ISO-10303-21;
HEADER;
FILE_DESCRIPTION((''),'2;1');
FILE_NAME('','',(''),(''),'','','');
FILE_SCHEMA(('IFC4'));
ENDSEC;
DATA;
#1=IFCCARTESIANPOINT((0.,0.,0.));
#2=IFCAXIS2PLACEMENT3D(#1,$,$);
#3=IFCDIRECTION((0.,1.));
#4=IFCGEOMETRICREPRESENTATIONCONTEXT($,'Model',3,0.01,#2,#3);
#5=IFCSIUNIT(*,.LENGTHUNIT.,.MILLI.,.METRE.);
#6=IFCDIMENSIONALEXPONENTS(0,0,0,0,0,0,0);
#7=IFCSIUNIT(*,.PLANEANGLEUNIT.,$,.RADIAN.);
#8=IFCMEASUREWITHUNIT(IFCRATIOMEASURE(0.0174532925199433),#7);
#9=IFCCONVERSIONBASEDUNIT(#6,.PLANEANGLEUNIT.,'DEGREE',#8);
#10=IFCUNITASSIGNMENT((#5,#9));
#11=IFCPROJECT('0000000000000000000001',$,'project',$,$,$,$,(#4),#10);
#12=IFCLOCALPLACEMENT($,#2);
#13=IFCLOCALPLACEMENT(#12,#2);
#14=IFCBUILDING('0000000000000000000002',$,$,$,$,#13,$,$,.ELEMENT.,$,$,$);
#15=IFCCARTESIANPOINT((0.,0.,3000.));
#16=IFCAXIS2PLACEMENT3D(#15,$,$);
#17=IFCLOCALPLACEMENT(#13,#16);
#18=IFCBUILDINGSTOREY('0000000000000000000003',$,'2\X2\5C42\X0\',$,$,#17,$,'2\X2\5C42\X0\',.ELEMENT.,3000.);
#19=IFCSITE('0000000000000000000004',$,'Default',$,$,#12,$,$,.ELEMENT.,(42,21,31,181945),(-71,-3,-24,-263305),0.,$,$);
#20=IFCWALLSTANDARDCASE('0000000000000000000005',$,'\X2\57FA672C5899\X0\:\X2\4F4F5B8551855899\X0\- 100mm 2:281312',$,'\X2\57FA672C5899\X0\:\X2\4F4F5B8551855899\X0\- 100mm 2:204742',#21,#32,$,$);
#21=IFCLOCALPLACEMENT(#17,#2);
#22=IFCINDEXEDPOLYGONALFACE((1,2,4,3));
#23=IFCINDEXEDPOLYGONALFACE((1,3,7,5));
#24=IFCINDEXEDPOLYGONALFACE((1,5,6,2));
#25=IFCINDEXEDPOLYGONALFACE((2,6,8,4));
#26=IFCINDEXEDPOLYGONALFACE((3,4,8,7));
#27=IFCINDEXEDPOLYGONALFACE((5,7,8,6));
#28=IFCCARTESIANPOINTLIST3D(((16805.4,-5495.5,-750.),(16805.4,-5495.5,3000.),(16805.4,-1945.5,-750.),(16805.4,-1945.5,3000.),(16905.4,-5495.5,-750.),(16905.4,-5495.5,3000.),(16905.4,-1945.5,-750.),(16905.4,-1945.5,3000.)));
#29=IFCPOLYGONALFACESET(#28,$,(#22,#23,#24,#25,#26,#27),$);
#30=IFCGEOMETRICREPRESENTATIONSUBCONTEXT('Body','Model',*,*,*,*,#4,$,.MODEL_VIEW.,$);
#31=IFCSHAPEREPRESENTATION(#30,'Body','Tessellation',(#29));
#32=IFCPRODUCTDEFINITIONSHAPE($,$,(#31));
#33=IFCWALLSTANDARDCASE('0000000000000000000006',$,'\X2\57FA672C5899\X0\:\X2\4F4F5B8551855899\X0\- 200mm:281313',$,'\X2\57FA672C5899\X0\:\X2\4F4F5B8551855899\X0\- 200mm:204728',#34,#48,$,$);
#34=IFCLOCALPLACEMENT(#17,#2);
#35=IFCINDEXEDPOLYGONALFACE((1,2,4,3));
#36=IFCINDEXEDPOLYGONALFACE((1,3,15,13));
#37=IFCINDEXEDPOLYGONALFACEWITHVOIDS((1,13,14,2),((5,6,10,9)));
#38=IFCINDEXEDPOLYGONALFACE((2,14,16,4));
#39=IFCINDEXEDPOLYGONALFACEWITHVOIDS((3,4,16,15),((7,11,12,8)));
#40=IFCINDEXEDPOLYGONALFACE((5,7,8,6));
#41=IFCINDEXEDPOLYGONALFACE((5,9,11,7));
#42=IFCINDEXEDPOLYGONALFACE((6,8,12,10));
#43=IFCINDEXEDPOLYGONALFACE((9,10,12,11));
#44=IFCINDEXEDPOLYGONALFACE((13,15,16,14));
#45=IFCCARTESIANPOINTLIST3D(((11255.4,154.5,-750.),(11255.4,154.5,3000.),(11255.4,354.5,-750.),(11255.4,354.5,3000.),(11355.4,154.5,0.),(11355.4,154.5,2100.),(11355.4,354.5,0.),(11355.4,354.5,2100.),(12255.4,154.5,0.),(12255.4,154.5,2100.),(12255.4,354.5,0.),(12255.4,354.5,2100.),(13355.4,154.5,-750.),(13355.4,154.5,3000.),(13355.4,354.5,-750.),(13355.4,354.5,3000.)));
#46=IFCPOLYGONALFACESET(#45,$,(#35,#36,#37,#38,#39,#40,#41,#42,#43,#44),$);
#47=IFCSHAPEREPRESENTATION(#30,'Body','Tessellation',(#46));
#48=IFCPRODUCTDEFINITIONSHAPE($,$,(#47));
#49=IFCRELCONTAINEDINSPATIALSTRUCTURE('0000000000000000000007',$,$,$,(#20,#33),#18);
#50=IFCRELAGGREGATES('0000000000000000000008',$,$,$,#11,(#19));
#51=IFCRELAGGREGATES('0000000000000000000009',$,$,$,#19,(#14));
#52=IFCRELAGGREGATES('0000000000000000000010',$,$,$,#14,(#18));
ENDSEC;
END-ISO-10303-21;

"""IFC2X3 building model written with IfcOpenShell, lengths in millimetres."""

from ifc_helpers import new_model, entity, si_unit, converted_unit, direction, frame, frame_2d, origin, place, context, subcontext, project, spatial, rectangle, extrude, element, save


model = new_model("IFC2X3")

# Units and contexts
model_context = context("Model", 3, precision=0.01, world=origin(), true_north=direction((0.0, 1.0)))
body_context = subcontext(model_context, "Body", "Model", "MODEL_VIEW")
ifc_project = project(units=[si_unit("LENGTHUNIT", "METRE", prefix="MILLI"), converted_unit("PLANEANGLEUNIT", "DEGREE", entity("IfcRatioMeasure", 0.0174532925199433), si_unit("PLANEANGLEUNIT", "RADIAN"), dimensions=[0, 0, 0, 0, 0, 0, 0])], contexts=[model_context])

# Site, building, storey
site_placement = place(None, origin())
site = spatial("IfcSite", under=ifc_project, at=site_placement, Name="Default", CompositionType="ELEMENT", RefLatitude=(42, 21, 31, 181945), RefLongitude=(-71, -3, -24, -263305), RefElevation=0.0)
building_placement = place(site_placement, origin())
building = spatial("IfcBuilding", under=site, at=building_placement, CompositionType="ELEMENT")
storey_placement = place(building_placement, frame((0.0, 0.0, 3000.0)))
storey = spatial("IfcBuildingStorey", under=building, at=storey_placement, Name="2层", LongName="2层", CompositionType="ELEMENT", Elevation=3000.0)

# Wall
wall_1_placement = place(storey_placement, frame((16855.4, -1945.5, -750.0), z_axis=(0.0, 0.0, 1.0), x_axis=(0.0, -1.0, 0.0)))
element("IfcWallStandardCase", 1, at=wall_1_placement, inside=storey, Name="基本墙:住宅内墙- 100mm 2:281312", ObjectType="基本墙:住宅内墙- 100mm 2:204742", context=body_context, shape_type="SweptSolid", body=[
    extrude(rectangle(XDim=3550.0, YDim=100.0, at=frame_2d((1775.0, 0.0), x_axis=(-1.0, 0.0))), origin(), (0.0, 0.0, 1.0), 3750.0),
])

# Wall, opening
wall_2_placement = place(storey_placement, frame((11255.4, 254.5, -750.0)))
wall_2 = element("IfcWallStandardCase", 2, at=wall_2_placement, inside=storey, Name="基本墙:住宅内墙- 200mm:281313", ObjectType="基本墙:住宅内墙- 200mm:204728", context=body_context, shape_type="SweptSolid", body=[
    extrude(rectangle(XDim=2100.0, YDim=200.0, at=frame_2d((1050.0, 0.0), x_axis=(-1.0, 0.0))), origin(), (0.0, 0.0, 1.0), 3750.0),
])
opening_placement = place(wall_2_placement, frame((100.0, -100.0, 750.0)))
element("IfcOpeningElement", 3, at=opening_placement, cuts=wall_2, ObjectType="Opening", context=body_context, shape_type="SweptSolid", body=[
    extrude(rectangle(XDim=2100.0, YDim=900.0, at=frame_2d((1050.0, 450.0), x_axis=(1.0, 0.0))), frame((0.0, 0.0, 0.0), z_axis=(0.0, 1.0, 0.0), x_axis=(0.0, 0.0, 1.0)), (0.0, 0.0, 1.0), 200.0),
])

save(model, "model.ifc")
